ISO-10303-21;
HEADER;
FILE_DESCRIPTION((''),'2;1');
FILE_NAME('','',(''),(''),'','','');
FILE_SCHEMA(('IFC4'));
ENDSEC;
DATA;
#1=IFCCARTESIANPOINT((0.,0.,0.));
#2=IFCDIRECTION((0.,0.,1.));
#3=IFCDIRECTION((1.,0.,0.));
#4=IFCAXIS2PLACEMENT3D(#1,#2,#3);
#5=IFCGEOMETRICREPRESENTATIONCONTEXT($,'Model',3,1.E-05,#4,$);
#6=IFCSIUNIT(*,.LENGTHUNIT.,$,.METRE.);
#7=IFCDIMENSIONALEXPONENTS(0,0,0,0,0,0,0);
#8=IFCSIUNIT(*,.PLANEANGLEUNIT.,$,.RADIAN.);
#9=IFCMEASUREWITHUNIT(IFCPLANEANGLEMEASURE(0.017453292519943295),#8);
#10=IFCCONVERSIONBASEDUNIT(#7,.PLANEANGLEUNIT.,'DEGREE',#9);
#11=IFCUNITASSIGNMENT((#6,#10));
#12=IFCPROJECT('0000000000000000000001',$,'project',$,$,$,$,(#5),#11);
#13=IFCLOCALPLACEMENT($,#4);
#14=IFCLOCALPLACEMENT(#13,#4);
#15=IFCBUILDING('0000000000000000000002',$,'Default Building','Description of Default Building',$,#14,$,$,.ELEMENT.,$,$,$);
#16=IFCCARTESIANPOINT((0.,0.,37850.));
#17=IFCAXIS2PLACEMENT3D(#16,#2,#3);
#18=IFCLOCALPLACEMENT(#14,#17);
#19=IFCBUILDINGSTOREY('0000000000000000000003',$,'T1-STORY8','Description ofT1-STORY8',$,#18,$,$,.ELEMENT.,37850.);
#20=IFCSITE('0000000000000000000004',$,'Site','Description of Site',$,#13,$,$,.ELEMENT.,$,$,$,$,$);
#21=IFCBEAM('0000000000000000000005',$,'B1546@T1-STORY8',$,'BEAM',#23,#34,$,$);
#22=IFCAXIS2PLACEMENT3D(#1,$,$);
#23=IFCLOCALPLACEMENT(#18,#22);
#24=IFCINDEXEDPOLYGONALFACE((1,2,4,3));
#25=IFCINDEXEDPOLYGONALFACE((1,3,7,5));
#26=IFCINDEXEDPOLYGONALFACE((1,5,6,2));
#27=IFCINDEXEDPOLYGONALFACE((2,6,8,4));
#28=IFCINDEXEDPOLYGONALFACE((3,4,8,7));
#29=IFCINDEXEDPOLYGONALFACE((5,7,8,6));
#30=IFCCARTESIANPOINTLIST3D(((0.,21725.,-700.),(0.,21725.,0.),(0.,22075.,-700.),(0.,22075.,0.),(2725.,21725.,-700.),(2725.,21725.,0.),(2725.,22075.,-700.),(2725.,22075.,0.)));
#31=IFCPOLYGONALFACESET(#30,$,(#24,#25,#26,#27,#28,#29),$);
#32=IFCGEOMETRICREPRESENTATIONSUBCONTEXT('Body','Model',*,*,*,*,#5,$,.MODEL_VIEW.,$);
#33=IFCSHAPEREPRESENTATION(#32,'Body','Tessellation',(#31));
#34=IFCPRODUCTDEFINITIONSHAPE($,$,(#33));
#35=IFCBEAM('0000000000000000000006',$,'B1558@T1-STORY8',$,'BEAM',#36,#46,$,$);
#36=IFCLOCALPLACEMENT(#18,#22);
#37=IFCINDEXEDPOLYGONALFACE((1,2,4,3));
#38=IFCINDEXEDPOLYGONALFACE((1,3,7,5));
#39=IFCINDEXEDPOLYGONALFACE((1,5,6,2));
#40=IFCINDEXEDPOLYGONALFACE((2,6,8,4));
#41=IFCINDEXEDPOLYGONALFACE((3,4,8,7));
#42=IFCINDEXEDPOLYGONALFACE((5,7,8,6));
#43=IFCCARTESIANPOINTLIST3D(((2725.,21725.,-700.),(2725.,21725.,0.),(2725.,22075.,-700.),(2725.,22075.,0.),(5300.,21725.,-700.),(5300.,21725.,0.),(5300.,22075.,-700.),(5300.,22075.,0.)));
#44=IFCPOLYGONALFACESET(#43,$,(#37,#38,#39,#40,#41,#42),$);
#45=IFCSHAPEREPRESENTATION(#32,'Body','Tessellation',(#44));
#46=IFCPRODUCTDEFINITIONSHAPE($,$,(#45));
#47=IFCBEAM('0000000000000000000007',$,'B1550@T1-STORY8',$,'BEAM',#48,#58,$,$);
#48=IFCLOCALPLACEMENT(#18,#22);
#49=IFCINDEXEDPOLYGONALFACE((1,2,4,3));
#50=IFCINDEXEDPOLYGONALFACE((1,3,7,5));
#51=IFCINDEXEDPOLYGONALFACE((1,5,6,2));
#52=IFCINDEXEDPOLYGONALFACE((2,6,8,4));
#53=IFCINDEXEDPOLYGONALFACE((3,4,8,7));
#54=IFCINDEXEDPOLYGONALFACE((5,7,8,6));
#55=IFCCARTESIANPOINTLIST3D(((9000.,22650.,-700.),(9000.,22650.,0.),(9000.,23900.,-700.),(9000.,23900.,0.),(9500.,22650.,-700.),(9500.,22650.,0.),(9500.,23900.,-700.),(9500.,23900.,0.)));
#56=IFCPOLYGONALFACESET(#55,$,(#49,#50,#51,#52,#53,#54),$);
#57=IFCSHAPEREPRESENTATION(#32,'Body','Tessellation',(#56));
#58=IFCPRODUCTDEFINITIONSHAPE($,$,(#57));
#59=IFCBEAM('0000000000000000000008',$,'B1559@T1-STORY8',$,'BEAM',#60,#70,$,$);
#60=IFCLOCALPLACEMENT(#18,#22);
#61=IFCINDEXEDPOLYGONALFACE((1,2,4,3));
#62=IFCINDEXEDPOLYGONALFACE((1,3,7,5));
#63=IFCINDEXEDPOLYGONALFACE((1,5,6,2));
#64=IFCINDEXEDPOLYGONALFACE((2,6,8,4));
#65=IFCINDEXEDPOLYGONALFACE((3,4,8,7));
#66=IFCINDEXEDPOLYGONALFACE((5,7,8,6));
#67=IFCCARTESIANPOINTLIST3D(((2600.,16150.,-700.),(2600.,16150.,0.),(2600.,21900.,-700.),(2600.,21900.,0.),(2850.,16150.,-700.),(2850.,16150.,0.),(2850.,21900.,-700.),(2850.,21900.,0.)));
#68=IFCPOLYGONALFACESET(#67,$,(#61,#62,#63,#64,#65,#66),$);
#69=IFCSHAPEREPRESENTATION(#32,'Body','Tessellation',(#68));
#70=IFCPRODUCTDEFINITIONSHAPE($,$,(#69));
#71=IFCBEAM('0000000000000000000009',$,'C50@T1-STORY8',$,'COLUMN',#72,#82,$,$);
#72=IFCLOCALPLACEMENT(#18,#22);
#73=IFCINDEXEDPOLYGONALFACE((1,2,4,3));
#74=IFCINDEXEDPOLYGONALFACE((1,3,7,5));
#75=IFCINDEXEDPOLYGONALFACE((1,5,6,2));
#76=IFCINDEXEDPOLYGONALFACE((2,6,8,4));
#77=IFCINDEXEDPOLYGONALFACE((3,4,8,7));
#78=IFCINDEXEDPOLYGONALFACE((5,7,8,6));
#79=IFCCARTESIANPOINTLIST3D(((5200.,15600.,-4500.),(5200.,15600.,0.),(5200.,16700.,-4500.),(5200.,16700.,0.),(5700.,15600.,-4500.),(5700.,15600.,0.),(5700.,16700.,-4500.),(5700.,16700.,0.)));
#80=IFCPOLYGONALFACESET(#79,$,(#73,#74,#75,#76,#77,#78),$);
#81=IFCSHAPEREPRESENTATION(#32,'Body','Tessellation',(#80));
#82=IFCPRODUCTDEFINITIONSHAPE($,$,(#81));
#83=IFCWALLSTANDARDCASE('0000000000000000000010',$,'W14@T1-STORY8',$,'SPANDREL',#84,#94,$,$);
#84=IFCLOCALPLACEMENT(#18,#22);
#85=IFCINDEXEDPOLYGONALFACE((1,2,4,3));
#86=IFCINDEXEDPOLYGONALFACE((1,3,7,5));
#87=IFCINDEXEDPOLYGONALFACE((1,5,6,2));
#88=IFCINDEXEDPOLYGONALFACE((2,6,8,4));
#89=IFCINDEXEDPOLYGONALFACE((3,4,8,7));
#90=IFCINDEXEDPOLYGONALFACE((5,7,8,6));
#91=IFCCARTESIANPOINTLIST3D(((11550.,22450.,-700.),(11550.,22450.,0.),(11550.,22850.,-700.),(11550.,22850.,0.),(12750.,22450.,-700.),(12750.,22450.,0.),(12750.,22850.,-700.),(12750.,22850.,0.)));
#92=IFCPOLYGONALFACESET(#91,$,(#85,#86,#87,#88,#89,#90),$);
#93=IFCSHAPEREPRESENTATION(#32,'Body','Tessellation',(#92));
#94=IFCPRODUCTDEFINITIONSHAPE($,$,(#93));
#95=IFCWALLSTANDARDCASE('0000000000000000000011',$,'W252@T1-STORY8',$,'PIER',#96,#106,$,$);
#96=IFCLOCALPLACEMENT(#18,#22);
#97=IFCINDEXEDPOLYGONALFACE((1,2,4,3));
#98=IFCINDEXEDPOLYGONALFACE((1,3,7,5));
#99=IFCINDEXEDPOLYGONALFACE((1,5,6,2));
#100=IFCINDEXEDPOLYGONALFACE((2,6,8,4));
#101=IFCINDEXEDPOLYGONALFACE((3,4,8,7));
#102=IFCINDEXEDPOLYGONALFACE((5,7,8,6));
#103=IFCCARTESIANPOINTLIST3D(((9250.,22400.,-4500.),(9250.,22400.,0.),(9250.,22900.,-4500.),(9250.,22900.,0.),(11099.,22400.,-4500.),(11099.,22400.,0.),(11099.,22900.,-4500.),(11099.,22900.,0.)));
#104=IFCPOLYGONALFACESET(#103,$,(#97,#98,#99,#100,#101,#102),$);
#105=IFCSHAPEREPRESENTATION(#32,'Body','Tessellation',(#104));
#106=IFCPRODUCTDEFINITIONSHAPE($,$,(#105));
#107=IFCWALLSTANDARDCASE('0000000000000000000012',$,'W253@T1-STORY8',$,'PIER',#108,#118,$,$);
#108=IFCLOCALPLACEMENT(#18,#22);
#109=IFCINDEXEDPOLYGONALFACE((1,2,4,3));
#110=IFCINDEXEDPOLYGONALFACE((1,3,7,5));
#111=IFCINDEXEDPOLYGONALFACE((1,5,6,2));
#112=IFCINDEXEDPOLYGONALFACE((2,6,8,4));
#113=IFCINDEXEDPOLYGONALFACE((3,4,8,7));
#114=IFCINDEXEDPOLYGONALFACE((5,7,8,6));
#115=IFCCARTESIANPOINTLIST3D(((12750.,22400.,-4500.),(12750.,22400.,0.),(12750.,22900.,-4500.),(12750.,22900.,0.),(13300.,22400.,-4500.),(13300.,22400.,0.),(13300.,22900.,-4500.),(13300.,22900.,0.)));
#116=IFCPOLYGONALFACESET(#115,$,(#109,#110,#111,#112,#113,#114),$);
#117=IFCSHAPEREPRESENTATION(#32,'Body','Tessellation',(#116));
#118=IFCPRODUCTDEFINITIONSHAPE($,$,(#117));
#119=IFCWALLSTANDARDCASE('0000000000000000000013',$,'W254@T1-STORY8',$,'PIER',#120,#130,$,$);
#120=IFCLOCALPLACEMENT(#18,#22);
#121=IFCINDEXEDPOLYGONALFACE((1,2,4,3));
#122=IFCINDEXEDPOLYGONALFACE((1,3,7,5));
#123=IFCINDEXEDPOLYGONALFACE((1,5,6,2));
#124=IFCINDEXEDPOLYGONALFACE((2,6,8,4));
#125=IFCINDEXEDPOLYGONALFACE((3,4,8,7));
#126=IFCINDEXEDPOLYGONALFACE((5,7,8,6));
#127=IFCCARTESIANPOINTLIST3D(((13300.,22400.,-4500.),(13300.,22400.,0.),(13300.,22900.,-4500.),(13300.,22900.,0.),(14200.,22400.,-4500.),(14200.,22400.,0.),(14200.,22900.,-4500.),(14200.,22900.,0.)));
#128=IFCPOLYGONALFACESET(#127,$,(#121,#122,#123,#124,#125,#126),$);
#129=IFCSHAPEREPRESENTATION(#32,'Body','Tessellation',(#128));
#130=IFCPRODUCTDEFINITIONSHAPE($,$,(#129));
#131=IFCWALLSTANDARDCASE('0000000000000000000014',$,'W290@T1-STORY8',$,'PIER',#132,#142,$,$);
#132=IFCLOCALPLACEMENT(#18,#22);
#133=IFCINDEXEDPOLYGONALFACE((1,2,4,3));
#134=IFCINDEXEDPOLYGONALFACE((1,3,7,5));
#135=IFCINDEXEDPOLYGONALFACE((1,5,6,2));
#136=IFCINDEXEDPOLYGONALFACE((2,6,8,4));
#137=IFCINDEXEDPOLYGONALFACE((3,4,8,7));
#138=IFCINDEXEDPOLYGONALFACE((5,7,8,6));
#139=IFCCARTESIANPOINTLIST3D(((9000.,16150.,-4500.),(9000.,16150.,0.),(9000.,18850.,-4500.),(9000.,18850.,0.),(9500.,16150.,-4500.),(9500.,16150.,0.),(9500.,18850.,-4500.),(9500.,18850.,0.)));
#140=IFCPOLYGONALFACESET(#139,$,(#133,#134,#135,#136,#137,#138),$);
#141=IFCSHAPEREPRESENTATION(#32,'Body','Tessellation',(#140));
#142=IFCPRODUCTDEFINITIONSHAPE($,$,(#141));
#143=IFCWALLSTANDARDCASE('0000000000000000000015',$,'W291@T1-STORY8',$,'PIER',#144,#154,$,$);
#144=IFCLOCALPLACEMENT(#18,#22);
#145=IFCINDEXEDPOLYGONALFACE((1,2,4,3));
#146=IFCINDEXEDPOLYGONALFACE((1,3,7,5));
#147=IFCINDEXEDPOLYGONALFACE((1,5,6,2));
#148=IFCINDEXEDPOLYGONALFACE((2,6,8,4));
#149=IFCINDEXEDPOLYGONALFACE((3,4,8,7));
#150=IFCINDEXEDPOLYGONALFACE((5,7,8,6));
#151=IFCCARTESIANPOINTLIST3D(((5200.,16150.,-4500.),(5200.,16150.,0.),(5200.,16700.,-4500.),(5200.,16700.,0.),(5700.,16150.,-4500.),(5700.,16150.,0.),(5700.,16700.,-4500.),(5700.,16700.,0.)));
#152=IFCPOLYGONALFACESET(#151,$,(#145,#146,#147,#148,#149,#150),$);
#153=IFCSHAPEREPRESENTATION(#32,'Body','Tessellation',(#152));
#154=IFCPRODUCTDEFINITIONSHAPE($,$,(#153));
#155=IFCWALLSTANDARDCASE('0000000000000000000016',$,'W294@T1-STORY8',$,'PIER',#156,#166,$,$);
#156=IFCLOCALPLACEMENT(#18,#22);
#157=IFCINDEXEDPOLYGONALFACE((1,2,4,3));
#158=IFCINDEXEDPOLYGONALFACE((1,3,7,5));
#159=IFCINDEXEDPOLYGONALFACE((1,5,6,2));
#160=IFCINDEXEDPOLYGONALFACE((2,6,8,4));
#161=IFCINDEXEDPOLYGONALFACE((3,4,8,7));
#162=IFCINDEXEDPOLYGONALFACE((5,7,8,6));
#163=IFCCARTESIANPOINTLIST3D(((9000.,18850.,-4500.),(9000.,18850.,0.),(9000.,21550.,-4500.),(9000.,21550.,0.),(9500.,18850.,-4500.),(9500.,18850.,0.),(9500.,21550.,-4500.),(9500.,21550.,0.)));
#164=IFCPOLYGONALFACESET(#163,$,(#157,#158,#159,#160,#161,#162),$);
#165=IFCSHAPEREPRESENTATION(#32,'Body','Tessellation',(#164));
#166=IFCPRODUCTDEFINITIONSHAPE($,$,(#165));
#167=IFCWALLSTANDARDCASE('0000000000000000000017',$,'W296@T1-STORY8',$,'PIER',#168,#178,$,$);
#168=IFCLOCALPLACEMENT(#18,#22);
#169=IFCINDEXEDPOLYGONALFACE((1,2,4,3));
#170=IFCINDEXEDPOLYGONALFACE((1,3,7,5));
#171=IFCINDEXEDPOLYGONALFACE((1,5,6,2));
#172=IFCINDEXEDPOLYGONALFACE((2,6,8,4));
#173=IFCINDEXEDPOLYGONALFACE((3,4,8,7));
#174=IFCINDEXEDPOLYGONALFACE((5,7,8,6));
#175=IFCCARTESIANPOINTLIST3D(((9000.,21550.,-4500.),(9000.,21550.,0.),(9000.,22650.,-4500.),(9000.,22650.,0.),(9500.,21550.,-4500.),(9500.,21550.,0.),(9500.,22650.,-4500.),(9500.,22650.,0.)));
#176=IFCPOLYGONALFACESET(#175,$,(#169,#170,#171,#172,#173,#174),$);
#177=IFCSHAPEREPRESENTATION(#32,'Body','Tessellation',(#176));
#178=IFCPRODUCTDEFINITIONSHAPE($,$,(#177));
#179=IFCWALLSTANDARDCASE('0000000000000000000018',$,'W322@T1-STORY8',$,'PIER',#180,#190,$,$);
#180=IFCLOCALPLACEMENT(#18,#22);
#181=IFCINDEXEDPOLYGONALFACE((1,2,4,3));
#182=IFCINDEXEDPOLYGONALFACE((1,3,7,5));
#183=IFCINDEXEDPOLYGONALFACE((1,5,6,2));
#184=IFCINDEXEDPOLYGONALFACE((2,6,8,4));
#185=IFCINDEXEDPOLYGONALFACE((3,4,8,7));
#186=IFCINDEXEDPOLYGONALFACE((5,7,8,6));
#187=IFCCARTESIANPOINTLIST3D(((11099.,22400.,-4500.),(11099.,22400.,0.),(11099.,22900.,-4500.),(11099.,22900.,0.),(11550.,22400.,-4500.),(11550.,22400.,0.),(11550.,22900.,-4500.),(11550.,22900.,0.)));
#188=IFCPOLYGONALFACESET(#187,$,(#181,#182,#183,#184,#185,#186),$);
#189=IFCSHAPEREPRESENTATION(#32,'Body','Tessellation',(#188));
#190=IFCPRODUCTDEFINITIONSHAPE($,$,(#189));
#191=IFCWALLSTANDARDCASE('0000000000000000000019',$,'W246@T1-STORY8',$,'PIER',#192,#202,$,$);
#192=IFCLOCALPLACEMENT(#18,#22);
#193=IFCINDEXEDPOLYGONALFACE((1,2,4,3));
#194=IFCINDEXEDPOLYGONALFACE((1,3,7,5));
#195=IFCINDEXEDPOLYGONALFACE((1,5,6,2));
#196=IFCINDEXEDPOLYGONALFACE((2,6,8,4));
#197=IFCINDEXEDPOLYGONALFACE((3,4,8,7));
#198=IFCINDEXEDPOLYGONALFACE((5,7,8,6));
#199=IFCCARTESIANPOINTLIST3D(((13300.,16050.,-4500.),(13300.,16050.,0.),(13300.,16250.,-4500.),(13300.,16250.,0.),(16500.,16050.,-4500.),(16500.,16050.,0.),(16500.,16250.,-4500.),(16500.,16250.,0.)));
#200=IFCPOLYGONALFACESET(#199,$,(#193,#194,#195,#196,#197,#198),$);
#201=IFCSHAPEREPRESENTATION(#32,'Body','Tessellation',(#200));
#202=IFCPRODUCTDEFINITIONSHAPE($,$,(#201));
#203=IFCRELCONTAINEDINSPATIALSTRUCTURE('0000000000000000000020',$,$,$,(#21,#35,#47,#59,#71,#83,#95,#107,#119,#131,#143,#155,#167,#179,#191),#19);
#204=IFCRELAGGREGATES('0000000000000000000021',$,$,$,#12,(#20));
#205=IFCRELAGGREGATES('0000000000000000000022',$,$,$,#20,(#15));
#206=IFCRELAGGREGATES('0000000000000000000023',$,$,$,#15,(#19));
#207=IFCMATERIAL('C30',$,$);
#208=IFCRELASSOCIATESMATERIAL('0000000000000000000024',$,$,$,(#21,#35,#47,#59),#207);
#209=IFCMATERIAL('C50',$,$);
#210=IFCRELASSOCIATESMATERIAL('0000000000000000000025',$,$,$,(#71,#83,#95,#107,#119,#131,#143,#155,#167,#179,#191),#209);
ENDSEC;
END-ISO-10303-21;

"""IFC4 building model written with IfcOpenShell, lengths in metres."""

from ifc_helpers import new_model, entity, si_unit, converted_unit, frame, origin_with_axes, place, context, subcontext, project, spatial, indexed_curve, rectangle, outline, extrude, material, element, save


model = new_model("IFC4")

# Units and contexts
model_context = context("Model", 3, precision=1e-05, world=origin_with_axes())
body_context = subcontext(model_context, "Body", "Model", "MODEL_VIEW")
ifc_project = project(units=[si_unit("LENGTHUNIT", "METRE"), converted_unit("PLANEANGLEUNIT", "DEGREE", entity("IfcPlaneAngleMeasure", 0.017453292519943295), si_unit("PLANEANGLEUNIT", "RADIAN"), dimensions=[0, 0, 0, 0, 0, 0, 0])], contexts=[model_context])

# Site, building, storey
site_placement = place(None, origin_with_axes())
site = spatial("IfcSite", under=ifc_project, at=site_placement, Name="Site", Description="Description of Site", CompositionType="ELEMENT")
building_placement = place(site_placement, origin_with_axes())
building = spatial("IfcBuilding", under=site, at=building_placement, Name="Default Building", Description="Description of Default Building", CompositionType="ELEMENT")
storey_placement = place(building_placement, frame((0.0, 0.0, 37850.0), z_axis=(0.0, 0.0, 1.0), x_axis=(1.0, 0.0, 0.0)))
storey = spatial("IfcBuildingStorey", under=building, at=storey_placement, Name="T1-STORY8", Description="Description ofT1-STORY8", CompositionType="ELEMENT", Elevation=37850.0)

# Beams
ifc_material_1 = material(Name="C30")
beam_1_placement = place(storey_placement, frame((0.0, 21900.0, -350.0), z_axis=(1.0, 0.0, 0.0), x_axis=(0.0, 1.0, 0.0)))
element("IfcBeam", 1, at=beam_1_placement, inside=storey, material=ifc_material_1, Name="B1546@T1-STORY8", ObjectType="BEAM", context=body_context, shape_type="SweptSolid", body=[
    extrude(rectangle(XDim=350.0, YDim=700.0), origin_with_axes(), (0.0, 0.0, 1.0), 2725.0),
])
beam_2_placement = place(storey_placement, frame((2725.0, 21900.0, -350.0), z_axis=(1.0, 0.0, 0.0), x_axis=(0.0, 1.0, 0.0)))
element("IfcBeam", 2, at=beam_2_placement, inside=storey, material=ifc_material_1, Name="B1558@T1-STORY8", ObjectType="BEAM", context=body_context, shape_type="SweptSolid", body=[
    extrude(rectangle(XDim=350.0, YDim=700.0), origin_with_axes(), (0.0, 0.0, 1.0), 2575.0),
])
beam_3_placement = place(storey_placement, frame((9250.0, 22650.0, -350.0), z_axis=(0.0, 1.0, 0.0), x_axis=(-1.0, 0.0, 0.0)))
element("IfcBeam", 3, at=beam_3_placement, inside=storey, material=ifc_material_1, Name="B1550@T1-STORY8", ObjectType="BEAM", context=body_context, shape_type="SweptSolid", body=[
    extrude(rectangle(XDim=500.0, YDim=700.0), origin_with_axes(), (0.0, 0.0, 1.0), 1250.0),
])
beam_4_placement = place(storey_placement, frame((2725.0, 16150.0, -350.0), z_axis=(0.0, 1.0, 0.0), x_axis=(-1.0, 0.0, 0.0)))
element("IfcBeam", 4, at=beam_4_placement, inside=storey, material=ifc_material_1, Name="B1559@T1-STORY8", ObjectType="BEAM", context=body_context, shape_type="SweptSolid", body=[
    extrude(rectangle(XDim=250.0, YDim=700.0), origin_with_axes(), (0.0, 0.0, 1.0), 5750.0),
])
ifc_material_2 = material(Name="C50")
beam_5_placement = place(storey_placement, frame((5450.0, 16150.0, -4500.0), z_axis=(0.0, 0.0, 1.0), x_axis=(-1.0, 0.0, 0.0)))
element("IfcBeam", 5, at=beam_5_placement, inside=storey, material=ifc_material_2, Name="C50@T1-STORY8", ObjectType="COLUMN", context=body_context, shape_type="SweptSolid", body=[
    extrude(rectangle(XDim=500.0, YDim=1100.0), origin_with_axes(), (0.0, 0.0, 1.0), 4500.0),
])

# Walls
wall_1_placement = place(storey_placement, frame((11550.0, 22650.0, -700.0), z_axis=(0.0, 0.0, 1.0), x_axis=(1.0, 0.0, 0.0)))
element("IfcWallStandardCase", 6, at=wall_1_placement, inside=storey, material=ifc_material_2, Name="W14@T1-STORY8", ObjectType="SPANDREL", context=body_context, shape_type="SweptSolid", body=[
    extrude(outline(indexed_curve([(0.0, -200.0), (0.0, 200.0), (1200.0, 200.0), (1200.0, -200.0), (0.0, -200.0)], self_intersect=False)), origin_with_axes(), (0.0, 0.0, 1.0), 700.0),
])
wall_2_placement = place(storey_placement, frame((9250.0, 22650.0, -4500.0), z_axis=(0.0, 0.0, 1.0), x_axis=(1.0, 0.0, 0.0)))
element("IfcWallStandardCase", 7, at=wall_2_placement, inside=storey, material=ifc_material_2, Name="W252@T1-STORY8", ObjectType="PIER", context=body_context, shape_type="SweptSolid", body=[
    extrude(outline(indexed_curve([(0.0, -250.0), (0.0, 250.0), (1849.0, 250.0), (1849.0, -250.0), (0.0, -250.0)], self_intersect=False)), origin_with_axes(), (0.0, 0.0, 1.0), 4500.0),
])
wall_3_placement = place(storey_placement, frame((12750.0, 22650.0, -4500.0), z_axis=(0.0, 0.0, 1.0), x_axis=(1.0, 0.0, 0.0)))
element("IfcWallStandardCase", 8, at=wall_3_placement, inside=storey, material=ifc_material_2, Name="W253@T1-STORY8", ObjectType="PIER", context=body_context, shape_type="SweptSolid", body=[
    extrude(outline(indexed_curve([(0.0, -250.0), (0.0, 250.0), (550.0, 250.0), (550.0, -250.0), (0.0, -250.0)], self_intersect=False)), origin_with_axes(), (0.0, 0.0, 1.0), 4500.0),
])
wall_4_placement = place(storey_placement, frame((13300.0, 22650.0, -4500.0), z_axis=(0.0, 0.0, 1.0), x_axis=(1.0, 0.0, 0.0)))
element("IfcWallStandardCase", 9, at=wall_4_placement, inside=storey, material=ifc_material_2, Name="W254@T1-STORY8", ObjectType="PIER", context=body_context, shape_type="SweptSolid", body=[
    extrude(outline(indexed_curve([(0.0, -250.0), (0.0, 250.0), (900.0, 250.0), (900.0, -250.0), (0.0, -250.0)], self_intersect=False)), origin_with_axes(), (0.0, 0.0, 1.0), 4500.0),
])
wall_5_placement = place(storey_placement, frame((9250.0, 16150.0, -4500.0), z_axis=(0.0, 0.0, 1.0), x_axis=(0.0, 1.0, 0.0)))
element("IfcWallStandardCase", 10, at=wall_5_placement, inside=storey, material=ifc_material_2, Name="W290@T1-STORY8", ObjectType="PIER", context=body_context, shape_type="SweptSolid", body=[
    extrude(outline(indexed_curve([(0.0, -250.0), (0.0, 250.0), (2700.0, 250.0), (2700.0, -250.0), (0.0, -250.0)], self_intersect=False)), origin_with_axes(), (0.0, 0.0, 1.0), 4500.0),
])
wall_6_placement = place(storey_placement, frame((5450.0, 16150.0, -4500.0), z_axis=(0.0, 0.0, 1.0), x_axis=(0.0, 1.0, 0.0)))
element("IfcWallStandardCase", 11, at=wall_6_placement, inside=storey, material=ifc_material_2, Name="W291@T1-STORY8", ObjectType="PIER", context=body_context, shape_type="SweptSolid", body=[
    extrude(outline(indexed_curve([(0.0, -250.0), (0.0, 250.0), (550.0, 250.0), (550.0, -250.0), (0.0, -250.0)], self_intersect=False)), origin_with_axes(), (0.0, 0.0, 1.0), 4500.0),
])
wall_7_placement = place(storey_placement, frame((9250.0, 18850.0, -4500.0), z_axis=(0.0, 0.0, 1.0), x_axis=(0.0, 1.0, 0.0)))
element("IfcWallStandardCase", 12, at=wall_7_placement, inside=storey, material=ifc_material_2, Name="W294@T1-STORY8", ObjectType="PIER", context=body_context, shape_type="SweptSolid", body=[
    extrude(outline(indexed_curve([(0.0, -250.0), (0.0, 250.0), (2700.0, 250.0), (2700.0, -250.0), (0.0, -250.0)], self_intersect=False)), origin_with_axes(), (0.0, 0.0, 1.0), 4500.0),
])
wall_8_placement = place(storey_placement, frame((9250.0, 21550.0, -4500.0), z_axis=(0.0, 0.0, 1.0), x_axis=(0.0, 1.0, 0.0)))
element("IfcWallStandardCase", 13, at=wall_8_placement, inside=storey, material=ifc_material_2, Name="W296@T1-STORY8", ObjectType="PIER", context=body_context, shape_type="SweptSolid", body=[
    extrude(outline(indexed_curve([(0.0, -250.0), (0.0, 250.0), (1100.0, 250.0), (1100.0, -250.0), (0.0, -250.0)], self_intersect=False)), origin_with_axes(), (0.0, 0.0, 1.0), 4500.0),
])
wall_9_placement = place(storey_placement, frame((11099.0, 22650.0, -4500.0), z_axis=(0.0, 0.0, 1.0), x_axis=(1.0, 0.0, 0.0)))
element("IfcWallStandardCase", 14, at=wall_9_placement, inside=storey, material=ifc_material_2, Name="W322@T1-STORY8", ObjectType="PIER", context=body_context, shape_type="SweptSolid", body=[
    extrude(outline(indexed_curve([(0.0, -250.0), (0.0, 250.0), (451.0, 250.0), (451.0, -250.0), (0.0, -250.0)], self_intersect=False)), origin_with_axes(), (0.0, 0.0, 1.0), 4500.0),
])
wall_10_placement = place(storey_placement, frame((13300.0, 16150.0, -4500.0), z_axis=(0.0, 0.0, 1.0), x_axis=(1.0, 0.0, 0.0)))
element("IfcWallStandardCase", 15, at=wall_10_placement, inside=storey, material=ifc_material_2, Name="W246@T1-STORY8", ObjectType="PIER", context=body_context, shape_type="SweptSolid", body=[
    extrude(outline(indexed_curve([(0.0, -100.0), (0.0, 100.0), (3200.0, 100.0), (3200.0, -100.0), (0.0, -100.0)], self_intersect=False)), origin_with_axes(), (0.0, 0.0, 1.0), 4500.0),
])

save(model, "model.ifc")
